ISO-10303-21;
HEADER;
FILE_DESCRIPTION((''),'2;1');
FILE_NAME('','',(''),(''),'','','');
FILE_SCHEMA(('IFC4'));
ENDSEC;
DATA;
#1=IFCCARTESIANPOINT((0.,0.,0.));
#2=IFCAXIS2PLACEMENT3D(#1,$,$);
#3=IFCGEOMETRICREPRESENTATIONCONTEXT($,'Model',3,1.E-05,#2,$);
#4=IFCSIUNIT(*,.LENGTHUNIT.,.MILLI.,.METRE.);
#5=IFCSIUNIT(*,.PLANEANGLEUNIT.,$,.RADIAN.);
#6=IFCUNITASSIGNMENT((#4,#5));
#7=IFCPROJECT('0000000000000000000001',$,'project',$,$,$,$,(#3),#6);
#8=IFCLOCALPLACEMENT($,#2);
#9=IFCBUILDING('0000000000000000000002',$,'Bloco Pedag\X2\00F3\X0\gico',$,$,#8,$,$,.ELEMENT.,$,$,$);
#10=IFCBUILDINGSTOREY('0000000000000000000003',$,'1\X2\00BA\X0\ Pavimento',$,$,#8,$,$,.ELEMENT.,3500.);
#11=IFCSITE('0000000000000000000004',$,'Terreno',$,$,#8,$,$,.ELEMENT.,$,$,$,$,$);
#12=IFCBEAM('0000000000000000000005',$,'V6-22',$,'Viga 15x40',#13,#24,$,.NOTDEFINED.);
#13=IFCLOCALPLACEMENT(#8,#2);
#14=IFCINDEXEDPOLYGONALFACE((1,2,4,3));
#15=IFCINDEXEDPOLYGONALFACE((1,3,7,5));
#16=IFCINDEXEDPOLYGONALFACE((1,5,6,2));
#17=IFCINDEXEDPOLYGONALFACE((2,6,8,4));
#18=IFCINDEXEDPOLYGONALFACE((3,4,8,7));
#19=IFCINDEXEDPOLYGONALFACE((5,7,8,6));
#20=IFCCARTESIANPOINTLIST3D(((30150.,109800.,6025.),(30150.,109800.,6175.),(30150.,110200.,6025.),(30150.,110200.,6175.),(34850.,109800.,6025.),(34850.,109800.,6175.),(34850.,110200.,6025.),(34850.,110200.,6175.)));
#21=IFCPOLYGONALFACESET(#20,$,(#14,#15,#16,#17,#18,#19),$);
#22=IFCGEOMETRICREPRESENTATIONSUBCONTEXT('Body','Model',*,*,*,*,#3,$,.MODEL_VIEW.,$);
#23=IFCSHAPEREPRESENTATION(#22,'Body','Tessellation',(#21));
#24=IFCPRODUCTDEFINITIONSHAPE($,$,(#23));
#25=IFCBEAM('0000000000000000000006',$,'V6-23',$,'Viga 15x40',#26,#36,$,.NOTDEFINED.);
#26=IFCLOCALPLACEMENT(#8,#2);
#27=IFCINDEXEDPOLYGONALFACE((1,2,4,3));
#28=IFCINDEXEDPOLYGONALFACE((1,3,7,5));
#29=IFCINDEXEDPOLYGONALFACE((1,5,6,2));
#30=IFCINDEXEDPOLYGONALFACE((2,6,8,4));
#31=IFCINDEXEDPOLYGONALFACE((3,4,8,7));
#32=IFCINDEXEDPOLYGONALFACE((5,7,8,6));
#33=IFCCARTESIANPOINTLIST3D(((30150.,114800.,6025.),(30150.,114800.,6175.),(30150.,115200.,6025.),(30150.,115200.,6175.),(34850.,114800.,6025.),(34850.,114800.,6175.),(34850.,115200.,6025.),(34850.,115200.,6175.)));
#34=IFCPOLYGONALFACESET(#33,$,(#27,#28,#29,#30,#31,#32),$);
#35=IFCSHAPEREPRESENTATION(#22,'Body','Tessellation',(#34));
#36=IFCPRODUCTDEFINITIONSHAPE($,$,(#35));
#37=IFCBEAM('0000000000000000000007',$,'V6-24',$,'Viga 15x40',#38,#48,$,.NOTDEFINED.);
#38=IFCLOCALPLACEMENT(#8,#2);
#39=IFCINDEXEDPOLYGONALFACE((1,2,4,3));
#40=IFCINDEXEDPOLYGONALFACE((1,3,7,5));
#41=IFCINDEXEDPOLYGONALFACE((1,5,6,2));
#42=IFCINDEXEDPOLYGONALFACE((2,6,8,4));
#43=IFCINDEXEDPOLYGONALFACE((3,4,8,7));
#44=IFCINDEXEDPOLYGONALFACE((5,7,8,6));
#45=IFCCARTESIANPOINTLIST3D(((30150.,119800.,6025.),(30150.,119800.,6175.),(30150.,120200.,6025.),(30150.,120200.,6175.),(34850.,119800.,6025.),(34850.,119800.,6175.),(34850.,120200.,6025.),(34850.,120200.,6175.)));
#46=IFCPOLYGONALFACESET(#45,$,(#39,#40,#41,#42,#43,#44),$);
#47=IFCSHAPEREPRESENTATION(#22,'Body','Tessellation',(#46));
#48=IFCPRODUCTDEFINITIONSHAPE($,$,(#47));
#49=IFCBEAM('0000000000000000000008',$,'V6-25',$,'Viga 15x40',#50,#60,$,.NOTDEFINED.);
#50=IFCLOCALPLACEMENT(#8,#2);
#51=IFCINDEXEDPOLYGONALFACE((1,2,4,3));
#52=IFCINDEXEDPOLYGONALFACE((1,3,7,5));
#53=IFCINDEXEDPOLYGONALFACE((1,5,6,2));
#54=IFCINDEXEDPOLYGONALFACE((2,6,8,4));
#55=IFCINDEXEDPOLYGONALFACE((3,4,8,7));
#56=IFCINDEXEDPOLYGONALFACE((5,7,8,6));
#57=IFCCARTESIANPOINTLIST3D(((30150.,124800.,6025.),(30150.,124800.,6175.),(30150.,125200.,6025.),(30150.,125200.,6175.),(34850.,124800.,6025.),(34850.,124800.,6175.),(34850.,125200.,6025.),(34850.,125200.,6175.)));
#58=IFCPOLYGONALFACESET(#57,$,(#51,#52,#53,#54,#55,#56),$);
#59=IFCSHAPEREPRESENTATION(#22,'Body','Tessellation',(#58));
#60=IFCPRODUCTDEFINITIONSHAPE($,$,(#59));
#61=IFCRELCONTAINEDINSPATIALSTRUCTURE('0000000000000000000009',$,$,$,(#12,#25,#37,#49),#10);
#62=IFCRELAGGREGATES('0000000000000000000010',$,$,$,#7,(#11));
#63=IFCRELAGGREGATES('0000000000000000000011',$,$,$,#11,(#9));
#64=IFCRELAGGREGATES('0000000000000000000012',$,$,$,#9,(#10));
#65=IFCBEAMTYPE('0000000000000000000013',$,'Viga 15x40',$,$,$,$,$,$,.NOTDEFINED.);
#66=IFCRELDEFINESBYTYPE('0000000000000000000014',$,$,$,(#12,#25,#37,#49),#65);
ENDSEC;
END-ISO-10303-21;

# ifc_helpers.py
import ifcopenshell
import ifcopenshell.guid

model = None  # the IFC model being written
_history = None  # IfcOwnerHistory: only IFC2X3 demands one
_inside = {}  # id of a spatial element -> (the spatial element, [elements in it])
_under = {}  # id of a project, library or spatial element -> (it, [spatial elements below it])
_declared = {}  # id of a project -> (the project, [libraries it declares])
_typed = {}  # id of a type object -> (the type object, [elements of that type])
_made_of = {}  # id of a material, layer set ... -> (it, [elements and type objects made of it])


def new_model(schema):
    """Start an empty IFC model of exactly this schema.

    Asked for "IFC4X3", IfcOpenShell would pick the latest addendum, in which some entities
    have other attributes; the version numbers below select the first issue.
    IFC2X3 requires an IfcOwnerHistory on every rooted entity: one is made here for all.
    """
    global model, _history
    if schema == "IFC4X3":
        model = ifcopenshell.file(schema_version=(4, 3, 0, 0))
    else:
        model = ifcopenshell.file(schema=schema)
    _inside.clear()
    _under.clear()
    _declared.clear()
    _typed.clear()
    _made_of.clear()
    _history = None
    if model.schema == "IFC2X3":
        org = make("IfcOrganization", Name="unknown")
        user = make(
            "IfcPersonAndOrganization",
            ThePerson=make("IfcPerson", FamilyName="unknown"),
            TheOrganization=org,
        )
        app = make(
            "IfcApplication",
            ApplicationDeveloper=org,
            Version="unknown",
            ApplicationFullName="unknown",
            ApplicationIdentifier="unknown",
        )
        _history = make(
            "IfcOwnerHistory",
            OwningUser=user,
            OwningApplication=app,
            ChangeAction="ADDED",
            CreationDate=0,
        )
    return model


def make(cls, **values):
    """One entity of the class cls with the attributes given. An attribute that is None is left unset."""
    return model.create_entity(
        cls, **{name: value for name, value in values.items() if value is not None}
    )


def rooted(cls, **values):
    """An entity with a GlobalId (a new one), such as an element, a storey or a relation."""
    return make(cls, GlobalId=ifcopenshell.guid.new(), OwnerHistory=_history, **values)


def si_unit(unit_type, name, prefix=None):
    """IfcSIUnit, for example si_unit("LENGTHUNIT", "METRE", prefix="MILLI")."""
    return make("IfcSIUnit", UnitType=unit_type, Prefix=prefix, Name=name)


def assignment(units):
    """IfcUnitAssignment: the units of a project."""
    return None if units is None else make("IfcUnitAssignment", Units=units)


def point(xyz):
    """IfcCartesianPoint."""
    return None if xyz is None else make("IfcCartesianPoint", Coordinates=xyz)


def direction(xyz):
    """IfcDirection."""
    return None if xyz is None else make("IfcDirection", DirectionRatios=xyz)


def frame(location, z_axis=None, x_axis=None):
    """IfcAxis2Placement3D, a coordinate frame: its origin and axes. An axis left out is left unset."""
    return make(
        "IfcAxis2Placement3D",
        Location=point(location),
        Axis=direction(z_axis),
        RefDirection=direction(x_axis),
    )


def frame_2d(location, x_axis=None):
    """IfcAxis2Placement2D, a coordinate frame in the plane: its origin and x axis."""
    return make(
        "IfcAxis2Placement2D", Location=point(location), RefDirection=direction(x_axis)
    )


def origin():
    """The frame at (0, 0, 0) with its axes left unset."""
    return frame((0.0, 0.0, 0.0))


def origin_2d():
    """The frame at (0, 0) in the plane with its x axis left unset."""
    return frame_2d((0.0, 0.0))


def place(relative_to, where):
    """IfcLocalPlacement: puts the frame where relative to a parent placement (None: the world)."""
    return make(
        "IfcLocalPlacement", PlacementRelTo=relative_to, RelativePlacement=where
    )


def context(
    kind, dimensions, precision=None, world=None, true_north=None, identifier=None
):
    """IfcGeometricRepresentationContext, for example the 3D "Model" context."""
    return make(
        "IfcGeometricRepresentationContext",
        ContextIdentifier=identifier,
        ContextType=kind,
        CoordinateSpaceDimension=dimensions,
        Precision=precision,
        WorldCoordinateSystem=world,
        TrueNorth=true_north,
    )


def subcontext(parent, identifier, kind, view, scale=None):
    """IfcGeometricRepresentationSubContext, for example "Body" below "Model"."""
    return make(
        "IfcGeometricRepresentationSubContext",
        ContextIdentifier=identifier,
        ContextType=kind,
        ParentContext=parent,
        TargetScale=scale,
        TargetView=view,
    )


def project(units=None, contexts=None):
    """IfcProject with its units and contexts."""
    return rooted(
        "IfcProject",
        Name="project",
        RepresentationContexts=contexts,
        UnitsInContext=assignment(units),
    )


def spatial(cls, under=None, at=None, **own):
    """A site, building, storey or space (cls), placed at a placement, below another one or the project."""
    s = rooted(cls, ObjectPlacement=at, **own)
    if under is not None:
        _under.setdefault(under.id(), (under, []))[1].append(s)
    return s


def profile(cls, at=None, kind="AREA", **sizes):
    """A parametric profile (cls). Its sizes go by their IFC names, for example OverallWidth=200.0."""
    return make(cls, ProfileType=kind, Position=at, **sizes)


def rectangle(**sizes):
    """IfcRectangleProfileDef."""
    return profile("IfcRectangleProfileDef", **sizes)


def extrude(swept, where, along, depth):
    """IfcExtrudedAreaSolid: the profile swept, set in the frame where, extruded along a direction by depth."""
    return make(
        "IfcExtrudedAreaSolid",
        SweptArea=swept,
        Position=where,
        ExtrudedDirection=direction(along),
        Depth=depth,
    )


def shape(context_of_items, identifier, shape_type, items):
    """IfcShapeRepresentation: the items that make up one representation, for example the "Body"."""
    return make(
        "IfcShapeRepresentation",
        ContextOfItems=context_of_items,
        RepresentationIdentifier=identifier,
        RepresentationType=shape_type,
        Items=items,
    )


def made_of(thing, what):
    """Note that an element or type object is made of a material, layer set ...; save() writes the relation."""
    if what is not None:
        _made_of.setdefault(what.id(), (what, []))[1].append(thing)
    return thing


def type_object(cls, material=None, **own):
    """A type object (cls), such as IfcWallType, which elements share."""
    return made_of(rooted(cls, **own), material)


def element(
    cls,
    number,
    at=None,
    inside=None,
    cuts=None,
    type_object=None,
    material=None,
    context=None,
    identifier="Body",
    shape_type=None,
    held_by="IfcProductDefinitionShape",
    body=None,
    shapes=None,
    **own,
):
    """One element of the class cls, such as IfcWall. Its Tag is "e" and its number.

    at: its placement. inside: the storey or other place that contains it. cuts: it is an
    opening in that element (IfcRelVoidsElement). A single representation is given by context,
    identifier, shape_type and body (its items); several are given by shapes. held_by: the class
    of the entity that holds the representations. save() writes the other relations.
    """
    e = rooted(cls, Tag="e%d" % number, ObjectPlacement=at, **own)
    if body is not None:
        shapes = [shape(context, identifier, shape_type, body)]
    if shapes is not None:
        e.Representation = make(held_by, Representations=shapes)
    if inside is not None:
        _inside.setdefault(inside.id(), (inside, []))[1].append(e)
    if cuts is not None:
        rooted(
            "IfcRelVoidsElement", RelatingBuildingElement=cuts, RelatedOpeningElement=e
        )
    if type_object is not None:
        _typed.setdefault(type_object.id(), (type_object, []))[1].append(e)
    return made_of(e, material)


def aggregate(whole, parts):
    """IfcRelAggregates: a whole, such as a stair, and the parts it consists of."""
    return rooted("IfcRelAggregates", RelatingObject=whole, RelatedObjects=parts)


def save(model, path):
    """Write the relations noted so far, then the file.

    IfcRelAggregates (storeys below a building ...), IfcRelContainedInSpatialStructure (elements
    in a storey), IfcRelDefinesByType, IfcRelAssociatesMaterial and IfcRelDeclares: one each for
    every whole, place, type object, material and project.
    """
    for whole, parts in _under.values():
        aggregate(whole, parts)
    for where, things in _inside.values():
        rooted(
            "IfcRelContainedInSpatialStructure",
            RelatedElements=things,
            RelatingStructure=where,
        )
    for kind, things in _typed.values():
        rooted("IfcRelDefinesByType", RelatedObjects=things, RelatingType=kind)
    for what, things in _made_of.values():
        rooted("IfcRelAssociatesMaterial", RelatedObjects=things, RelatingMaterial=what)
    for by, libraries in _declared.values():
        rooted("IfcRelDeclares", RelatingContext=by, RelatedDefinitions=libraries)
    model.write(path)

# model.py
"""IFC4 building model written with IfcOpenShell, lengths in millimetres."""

from ifc_helpers import new_model, si_unit, frame, origin, origin_2d, place, context, subcontext, project, spatial, rectangle, extrude, type_object, element, save


model = new_model("IFC4")

# Units and contexts
model_context = context("Model", 3, precision=1e-05, world=origin())
body_context = subcontext(model_context, "Body", "Model", "MODEL_VIEW")
ifc_project = project(units=[si_unit("LENGTHUNIT", "METRE", prefix="MILLI"), si_unit("PLANEANGLEUNIT", "RADIAN")], contexts=[model_context])

# Site, building, storey
placement = place(None, origin())
site = spatial("IfcSite", under=ifc_project, at=placement, Name="Terreno", CompositionType="ELEMENT")
building = spatial("IfcBuilding", under=site, at=placement, Name="Bloco Pedagógico", CompositionType="ELEMENT")
storey = spatial("IfcBuildingStorey", under=building, at=placement, Name="1º Pavimento", CompositionType="ELEMENT", Elevation=3500.0)

# Beams
beam_type = type_object("IfcBeamType", Name="Viga 15x40", PredefinedType="NOTDEFINED")
for number, where, z_axis, x_axis, name in (
    (1, (30150.0, 110000.0, 6100.0), (1.0, 0.0, 0.0), (0.0, 1.0, 0.0), "V6-22"),
    (2, (30150.0, 115000.0, 6100.0), (1.0, 0.0, 0.0), (0.0, 1.0, 0.0), "V6-23"),
    (3, (30150.0, 120000.0, 6100.0), (1.0, 0.0, 0.0), (0.0, 1.0, 0.0), "V6-24"),
    (4, (30150.0, 125000.0, 6100.0), (1.0, 0.0, 0.0), (0.0, 1.0, 0.0), "V6-25"),
):
    element("IfcBeam", number, at=place(None, frame(where, z_axis=z_axis, x_axis=x_axis)), inside=storey, type_object=beam_type, Name=name, ObjectType="Viga 15x40", PredefinedType="NOTDEFINED", context=body_context, shape_type="SweptSolid", body=[
        extrude(rectangle(XDim=400.0, YDim=150.0, at=origin_2d()), None, (0.0, 0.0, 1.0), 4700.0),
    ])

save(model, "model.ifc")
